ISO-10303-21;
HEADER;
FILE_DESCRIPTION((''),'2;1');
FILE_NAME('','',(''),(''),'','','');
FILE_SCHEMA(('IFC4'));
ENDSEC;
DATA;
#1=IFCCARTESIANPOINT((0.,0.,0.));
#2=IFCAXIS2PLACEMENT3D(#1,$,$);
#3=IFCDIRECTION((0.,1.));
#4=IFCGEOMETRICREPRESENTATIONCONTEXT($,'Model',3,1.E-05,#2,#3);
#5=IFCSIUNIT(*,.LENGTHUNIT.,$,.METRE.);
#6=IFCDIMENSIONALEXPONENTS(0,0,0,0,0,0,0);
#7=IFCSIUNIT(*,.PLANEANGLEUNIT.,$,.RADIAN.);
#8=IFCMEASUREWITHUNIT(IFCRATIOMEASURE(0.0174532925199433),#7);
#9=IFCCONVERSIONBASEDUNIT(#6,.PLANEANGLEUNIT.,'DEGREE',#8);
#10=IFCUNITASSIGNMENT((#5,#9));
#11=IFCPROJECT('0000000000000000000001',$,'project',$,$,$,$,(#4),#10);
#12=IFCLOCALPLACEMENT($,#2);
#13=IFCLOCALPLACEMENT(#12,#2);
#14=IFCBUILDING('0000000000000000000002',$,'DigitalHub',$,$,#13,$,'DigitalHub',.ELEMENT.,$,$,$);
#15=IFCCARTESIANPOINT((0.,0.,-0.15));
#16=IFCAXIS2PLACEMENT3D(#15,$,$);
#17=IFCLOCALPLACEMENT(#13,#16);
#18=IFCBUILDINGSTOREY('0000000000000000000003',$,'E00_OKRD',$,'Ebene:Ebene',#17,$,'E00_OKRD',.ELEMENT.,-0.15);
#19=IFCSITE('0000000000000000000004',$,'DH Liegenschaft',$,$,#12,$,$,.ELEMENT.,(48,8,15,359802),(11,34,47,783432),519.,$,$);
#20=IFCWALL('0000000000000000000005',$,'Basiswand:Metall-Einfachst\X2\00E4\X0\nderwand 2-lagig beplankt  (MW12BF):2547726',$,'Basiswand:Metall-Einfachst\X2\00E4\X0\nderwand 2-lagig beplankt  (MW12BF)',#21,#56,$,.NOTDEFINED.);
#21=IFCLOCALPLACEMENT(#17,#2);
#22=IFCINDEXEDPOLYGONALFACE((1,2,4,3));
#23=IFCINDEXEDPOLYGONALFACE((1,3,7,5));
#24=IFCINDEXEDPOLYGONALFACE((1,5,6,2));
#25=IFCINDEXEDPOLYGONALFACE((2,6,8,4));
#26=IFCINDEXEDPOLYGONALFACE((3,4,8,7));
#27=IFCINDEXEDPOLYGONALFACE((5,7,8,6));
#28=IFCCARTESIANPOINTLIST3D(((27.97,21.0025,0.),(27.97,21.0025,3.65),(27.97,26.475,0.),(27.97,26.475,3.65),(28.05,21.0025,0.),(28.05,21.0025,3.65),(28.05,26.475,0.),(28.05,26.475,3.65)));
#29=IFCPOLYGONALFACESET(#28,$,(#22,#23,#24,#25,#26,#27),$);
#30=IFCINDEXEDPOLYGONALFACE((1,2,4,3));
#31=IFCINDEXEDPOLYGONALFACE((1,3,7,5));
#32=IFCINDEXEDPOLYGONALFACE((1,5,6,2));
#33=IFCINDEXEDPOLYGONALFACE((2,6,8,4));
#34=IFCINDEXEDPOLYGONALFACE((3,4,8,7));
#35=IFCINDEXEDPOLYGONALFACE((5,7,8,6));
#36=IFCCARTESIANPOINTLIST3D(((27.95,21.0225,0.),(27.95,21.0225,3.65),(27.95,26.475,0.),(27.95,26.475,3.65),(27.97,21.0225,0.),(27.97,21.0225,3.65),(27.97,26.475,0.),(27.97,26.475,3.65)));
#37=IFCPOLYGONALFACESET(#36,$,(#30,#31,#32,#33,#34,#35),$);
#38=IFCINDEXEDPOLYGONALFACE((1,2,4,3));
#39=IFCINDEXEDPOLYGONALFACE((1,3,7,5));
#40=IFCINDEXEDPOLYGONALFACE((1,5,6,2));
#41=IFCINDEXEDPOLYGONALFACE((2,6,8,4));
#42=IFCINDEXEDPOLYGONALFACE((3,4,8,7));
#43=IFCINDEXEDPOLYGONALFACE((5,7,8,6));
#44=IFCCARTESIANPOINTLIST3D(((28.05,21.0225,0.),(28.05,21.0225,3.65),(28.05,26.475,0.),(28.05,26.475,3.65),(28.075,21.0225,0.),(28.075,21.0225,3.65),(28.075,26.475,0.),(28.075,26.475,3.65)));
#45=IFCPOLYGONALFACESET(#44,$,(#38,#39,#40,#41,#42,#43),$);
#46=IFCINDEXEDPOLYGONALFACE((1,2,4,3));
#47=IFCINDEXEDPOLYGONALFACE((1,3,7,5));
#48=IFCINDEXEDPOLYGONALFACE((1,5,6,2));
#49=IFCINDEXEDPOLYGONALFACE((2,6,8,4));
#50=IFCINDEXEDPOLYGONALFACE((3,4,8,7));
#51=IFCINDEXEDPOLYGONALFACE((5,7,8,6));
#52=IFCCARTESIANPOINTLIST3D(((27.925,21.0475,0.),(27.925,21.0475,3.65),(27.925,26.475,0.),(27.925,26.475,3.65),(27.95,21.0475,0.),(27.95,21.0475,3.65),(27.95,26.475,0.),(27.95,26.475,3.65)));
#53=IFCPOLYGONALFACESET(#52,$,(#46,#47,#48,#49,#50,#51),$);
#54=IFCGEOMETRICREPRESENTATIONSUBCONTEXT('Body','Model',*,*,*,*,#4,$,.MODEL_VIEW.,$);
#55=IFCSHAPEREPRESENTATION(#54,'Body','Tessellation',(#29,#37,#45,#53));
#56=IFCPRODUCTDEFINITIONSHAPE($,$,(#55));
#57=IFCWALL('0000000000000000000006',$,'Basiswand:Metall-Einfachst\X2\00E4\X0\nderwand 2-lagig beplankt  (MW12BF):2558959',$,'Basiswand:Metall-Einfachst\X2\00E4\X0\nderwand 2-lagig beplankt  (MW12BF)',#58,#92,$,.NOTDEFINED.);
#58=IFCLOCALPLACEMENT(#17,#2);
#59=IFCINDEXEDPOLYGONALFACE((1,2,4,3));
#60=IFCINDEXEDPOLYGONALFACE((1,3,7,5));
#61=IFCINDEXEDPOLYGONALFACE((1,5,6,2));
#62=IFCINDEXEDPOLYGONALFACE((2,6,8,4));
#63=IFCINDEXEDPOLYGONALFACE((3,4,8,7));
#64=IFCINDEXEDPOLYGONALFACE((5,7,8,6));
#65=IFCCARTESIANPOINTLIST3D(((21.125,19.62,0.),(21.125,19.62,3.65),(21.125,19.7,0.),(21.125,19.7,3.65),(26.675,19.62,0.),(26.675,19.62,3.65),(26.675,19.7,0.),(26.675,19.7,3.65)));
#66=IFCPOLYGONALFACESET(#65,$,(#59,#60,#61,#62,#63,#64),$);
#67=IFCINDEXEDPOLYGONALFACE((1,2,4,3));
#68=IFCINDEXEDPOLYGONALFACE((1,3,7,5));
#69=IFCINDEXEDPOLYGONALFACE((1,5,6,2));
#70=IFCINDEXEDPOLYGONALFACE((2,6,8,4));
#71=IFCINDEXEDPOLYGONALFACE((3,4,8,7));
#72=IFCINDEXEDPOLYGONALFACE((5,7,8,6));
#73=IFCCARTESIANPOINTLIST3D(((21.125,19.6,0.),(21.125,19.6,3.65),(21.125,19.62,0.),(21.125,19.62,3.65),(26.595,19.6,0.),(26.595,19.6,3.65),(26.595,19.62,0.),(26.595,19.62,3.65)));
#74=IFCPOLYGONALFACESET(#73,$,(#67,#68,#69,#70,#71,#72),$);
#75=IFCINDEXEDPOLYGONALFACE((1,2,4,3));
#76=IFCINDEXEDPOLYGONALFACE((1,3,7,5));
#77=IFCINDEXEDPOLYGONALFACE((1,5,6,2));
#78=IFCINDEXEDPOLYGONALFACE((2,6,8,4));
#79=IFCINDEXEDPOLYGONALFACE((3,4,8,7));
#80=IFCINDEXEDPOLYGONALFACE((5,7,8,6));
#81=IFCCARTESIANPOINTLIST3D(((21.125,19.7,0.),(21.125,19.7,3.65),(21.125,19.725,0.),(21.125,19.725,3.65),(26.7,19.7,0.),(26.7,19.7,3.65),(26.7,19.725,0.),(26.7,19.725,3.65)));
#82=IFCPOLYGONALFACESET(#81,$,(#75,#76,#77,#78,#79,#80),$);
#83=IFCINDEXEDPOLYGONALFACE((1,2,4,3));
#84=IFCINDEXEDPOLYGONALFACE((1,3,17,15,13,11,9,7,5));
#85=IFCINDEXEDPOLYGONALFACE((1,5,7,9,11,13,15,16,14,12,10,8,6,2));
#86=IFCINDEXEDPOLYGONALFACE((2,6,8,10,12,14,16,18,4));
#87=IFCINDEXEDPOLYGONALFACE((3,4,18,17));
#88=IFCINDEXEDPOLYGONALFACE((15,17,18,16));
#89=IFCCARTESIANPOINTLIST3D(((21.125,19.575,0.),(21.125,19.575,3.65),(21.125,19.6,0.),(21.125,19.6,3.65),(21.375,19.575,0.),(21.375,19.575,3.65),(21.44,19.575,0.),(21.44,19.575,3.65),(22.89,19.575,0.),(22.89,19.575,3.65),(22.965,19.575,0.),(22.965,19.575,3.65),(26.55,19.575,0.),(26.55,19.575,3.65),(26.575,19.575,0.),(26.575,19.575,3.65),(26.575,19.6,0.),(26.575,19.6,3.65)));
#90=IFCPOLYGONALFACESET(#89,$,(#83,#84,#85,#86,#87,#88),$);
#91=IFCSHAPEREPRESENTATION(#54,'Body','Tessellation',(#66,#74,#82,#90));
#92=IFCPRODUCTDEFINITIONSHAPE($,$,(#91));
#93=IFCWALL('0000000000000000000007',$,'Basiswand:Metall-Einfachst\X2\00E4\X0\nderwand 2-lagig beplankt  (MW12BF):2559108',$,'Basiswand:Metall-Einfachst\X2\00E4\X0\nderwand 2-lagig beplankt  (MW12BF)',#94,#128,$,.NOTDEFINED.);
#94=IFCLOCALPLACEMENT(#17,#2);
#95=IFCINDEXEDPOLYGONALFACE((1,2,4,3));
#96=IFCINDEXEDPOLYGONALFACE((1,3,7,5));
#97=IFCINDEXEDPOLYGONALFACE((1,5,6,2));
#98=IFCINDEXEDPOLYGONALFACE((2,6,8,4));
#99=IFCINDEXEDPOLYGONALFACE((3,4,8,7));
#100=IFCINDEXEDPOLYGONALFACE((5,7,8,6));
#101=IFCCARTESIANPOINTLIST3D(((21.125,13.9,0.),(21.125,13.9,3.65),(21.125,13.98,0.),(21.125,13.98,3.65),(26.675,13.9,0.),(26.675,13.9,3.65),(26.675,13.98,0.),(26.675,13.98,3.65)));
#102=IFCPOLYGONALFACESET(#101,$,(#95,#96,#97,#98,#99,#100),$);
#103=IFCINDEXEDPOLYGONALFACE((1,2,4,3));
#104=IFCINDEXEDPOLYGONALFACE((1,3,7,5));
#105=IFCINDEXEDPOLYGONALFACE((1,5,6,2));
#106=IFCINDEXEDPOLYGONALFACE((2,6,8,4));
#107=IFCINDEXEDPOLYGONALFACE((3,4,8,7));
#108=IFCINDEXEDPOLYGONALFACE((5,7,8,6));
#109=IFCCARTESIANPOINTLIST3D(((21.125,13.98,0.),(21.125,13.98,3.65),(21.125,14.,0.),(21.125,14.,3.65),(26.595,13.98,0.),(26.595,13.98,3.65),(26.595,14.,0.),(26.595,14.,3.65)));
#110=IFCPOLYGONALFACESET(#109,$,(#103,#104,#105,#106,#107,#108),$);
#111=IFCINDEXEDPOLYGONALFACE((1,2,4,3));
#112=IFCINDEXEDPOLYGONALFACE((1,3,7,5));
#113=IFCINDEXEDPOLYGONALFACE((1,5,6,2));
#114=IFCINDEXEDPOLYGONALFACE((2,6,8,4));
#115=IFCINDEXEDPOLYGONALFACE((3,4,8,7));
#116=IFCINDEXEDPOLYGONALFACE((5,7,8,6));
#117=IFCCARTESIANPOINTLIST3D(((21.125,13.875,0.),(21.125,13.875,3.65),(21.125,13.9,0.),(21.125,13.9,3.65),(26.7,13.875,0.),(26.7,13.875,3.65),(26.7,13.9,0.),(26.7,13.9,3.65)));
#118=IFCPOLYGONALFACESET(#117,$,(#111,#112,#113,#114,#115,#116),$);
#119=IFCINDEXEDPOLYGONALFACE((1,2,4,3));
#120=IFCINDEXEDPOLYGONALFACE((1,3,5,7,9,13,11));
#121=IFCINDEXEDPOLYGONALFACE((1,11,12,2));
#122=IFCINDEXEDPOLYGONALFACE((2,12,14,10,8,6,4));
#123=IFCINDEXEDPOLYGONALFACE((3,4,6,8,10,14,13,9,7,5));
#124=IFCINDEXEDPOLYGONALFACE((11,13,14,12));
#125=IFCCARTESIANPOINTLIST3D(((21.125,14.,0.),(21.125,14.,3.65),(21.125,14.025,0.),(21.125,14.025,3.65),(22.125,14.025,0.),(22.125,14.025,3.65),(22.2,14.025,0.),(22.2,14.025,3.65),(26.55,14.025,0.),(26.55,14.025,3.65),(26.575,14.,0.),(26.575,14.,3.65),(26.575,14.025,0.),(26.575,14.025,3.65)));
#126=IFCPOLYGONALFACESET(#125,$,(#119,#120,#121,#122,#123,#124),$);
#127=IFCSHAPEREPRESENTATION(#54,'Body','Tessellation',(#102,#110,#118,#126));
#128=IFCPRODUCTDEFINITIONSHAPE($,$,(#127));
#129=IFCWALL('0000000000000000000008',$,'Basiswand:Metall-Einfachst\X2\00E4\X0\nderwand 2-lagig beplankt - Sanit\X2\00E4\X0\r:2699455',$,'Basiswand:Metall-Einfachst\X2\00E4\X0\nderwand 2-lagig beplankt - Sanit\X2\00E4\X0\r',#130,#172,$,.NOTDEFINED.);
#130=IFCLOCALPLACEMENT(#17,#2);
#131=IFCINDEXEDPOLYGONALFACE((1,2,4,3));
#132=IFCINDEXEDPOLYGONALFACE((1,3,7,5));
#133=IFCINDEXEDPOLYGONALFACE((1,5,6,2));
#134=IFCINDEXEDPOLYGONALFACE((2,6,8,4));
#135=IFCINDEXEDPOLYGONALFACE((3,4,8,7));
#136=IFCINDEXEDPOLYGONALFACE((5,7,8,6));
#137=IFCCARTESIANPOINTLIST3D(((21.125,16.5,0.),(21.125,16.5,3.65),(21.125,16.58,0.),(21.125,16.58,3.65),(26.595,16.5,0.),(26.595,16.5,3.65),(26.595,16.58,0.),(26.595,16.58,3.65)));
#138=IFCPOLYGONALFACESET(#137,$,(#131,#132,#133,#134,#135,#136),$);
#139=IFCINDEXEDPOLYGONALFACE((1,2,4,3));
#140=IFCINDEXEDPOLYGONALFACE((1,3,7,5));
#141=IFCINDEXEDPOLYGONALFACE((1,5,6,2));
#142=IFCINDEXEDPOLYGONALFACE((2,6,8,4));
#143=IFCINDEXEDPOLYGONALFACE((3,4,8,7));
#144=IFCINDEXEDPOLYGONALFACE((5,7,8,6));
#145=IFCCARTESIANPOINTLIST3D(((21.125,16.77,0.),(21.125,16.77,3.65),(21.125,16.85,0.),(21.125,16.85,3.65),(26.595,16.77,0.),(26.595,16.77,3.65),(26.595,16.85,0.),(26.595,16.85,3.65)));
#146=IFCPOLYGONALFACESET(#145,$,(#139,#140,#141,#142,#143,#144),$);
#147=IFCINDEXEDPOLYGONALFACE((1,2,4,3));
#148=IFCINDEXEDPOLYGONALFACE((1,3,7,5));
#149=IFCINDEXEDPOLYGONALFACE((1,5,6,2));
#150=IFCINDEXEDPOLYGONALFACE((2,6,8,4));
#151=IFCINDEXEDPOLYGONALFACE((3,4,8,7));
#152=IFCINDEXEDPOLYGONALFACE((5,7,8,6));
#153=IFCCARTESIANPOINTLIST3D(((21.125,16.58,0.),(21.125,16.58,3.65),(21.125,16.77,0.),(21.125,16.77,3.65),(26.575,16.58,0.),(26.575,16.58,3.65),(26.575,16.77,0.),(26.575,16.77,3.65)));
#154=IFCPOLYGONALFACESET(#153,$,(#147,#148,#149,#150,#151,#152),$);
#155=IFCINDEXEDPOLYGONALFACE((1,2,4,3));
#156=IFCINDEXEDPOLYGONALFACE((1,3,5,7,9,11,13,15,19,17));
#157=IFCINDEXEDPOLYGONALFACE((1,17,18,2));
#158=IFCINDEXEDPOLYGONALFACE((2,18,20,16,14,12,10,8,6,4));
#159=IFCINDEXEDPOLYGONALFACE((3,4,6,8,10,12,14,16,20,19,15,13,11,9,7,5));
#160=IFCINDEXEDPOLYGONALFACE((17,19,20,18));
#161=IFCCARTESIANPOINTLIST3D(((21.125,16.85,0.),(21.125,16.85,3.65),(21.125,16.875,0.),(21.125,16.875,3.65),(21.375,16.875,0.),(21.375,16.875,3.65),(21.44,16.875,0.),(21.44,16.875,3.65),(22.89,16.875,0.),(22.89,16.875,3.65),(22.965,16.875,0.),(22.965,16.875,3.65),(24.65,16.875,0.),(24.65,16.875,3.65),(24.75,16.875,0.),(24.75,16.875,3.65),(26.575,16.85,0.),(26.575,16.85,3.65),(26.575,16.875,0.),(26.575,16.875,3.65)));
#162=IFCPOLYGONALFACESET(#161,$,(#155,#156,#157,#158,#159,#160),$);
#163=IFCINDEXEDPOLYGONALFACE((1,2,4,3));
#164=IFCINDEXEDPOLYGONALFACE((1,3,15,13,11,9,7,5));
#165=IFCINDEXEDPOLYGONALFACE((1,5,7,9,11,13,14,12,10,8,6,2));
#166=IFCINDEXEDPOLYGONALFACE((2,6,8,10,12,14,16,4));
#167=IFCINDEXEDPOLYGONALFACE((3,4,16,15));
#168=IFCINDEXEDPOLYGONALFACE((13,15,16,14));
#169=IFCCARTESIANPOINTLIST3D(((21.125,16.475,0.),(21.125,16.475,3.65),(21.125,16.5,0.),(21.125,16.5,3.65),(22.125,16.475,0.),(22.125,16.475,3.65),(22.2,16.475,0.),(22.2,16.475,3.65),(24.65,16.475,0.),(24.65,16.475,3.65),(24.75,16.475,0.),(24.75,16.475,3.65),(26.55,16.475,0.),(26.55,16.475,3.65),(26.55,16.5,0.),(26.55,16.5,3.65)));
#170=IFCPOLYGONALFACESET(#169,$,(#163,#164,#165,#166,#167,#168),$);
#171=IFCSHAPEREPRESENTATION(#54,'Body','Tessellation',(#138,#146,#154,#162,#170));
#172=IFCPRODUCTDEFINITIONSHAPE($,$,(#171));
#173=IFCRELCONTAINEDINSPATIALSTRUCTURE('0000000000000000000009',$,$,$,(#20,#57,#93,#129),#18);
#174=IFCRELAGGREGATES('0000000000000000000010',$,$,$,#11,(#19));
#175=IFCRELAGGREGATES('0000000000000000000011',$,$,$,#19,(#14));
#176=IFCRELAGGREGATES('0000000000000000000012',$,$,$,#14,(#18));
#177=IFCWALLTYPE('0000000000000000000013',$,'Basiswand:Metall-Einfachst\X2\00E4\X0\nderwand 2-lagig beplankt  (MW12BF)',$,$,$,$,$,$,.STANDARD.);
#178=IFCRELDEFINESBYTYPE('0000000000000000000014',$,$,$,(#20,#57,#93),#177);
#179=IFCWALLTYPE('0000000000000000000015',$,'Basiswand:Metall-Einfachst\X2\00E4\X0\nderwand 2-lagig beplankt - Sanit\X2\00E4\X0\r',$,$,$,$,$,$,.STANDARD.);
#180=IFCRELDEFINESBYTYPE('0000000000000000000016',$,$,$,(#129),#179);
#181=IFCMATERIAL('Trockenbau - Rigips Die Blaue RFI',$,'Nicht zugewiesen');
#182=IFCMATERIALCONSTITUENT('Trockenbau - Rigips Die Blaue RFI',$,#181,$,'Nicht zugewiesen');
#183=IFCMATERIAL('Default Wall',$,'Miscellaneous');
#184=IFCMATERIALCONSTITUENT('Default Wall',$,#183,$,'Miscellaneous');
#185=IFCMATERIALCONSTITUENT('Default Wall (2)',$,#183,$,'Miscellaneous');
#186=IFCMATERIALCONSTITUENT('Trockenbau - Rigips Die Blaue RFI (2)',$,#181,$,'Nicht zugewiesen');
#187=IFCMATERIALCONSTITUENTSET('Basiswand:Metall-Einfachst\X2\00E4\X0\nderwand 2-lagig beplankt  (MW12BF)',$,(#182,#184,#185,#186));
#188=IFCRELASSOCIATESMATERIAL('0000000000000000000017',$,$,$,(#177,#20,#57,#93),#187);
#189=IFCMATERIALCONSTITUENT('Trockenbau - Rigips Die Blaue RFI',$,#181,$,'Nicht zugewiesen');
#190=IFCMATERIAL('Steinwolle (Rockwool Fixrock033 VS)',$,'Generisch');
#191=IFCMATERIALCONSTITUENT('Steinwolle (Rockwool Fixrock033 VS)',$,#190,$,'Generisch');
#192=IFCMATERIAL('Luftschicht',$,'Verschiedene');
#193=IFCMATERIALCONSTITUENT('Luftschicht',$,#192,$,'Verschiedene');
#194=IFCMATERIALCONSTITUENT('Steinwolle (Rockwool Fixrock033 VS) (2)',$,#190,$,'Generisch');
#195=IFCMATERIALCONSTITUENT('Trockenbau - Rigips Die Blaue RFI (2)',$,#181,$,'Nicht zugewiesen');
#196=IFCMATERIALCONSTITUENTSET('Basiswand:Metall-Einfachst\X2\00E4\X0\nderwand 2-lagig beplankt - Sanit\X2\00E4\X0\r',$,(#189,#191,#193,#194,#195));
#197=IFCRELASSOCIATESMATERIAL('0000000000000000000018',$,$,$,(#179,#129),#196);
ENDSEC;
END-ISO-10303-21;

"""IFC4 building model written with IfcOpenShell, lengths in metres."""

from ifc_helpers import new_model, entity, si_unit, converted_unit, direction, frame, origin, place, context, subcontext, project, spatial, indexed_curve, outline, extrude, material, constituent, constituent_set, type_object, element, save


model = new_model("IFC4")

# Units and contexts
model_context = context("Model", 3, precision=1e-05, world=origin(), true_north=direction((0.0, 1.0)))
body_context = subcontext(model_context, "Body", "Model", "MODEL_VIEW")
ifc_project = project(units=[si_unit("LENGTHUNIT", "METRE"), converted_unit("PLANEANGLEUNIT", "DEGREE", entity("IfcRatioMeasure", 0.0174532925199433), si_unit("PLANEANGLEUNIT", "RADIAN"), dimensions=[0, 0, 0, 0, 0, 0, 0])], contexts=[model_context])

# Site, building, storey
site_placement = place(None, frame((0.0, 0.0, 0.0)))
site = spatial("IfcSite", under=ifc_project, at=site_placement, Name="DH Liegenschaft", CompositionType="ELEMENT", RefLatitude=(48, 8, 15, 359802), RefLongitude=(11, 34, 47, 783432), RefElevation=519.0)
building_placement = place(site_placement, origin())
building = spatial("IfcBuilding", under=site, at=building_placement, Name="DigitalHub", LongName="DigitalHub", CompositionType="ELEMENT")
storey_placement = place(building_placement, frame((0.0, 0.0, -0.15)))
storey = spatial("IfcBuildingStorey", under=building, at=storey_placement, Name="E00_OKRD", ObjectType="Ebene:Ebene", LongName="E00_OKRD", CompositionType="ELEMENT", Elevation=-0.15)

# Wall
ifc_material_1 = material(Name="Trockenbau - Rigips Die Blaue RFI", Category="Nicht zugewiesen")
ifc_constituent_1 = constituent(ifc_material_1, Name="Trockenbau - Rigips Die Blaue RFI", Category="Nicht zugewiesen")
ifc_material_2 = material(Name="Default Wall", Category="Miscellaneous")
ifc_constituent_2 = constituent(ifc_material_2, Name="Default Wall", Category="Miscellaneous")
ifc_constituent_3 = constituent(ifc_material_2, Name="Default Wall (2)", Category="Miscellaneous")
ifc_constituent_4 = constituent(ifc_material_1, Name="Trockenbau - Rigips Die Blaue RFI (2)", Category="Nicht zugewiesen")
ifc_constituent_set_1 = constituent_set(constituents=[ifc_constituent_1, ifc_constituent_2, ifc_constituent_3, ifc_constituent_4], Name="Basiswand:Metall-Einfachständerwand 2-lagig beplankt  (MW12BF)")
wall_type_1 = type_object("IfcWallType", Name="Basiswand:Metall-Einfachständerwand 2-lagig beplankt  (MW12BF)", PredefinedType="STANDARD", material=ifc_constituent_set_1)
wall_1_placement = place(storey_placement, frame((28.0, 26.475, 0.0), z_axis=(0.0, 0.0, 1.0), x_axis=(0.0, -1.0, 0.0)))
element("IfcWall", 1, at=wall_1_placement, inside=storey, type_object=wall_type_1, material=ifc_constituent_set_1, Name="Basiswand:Metall-Einfachständerwand 2-lagig beplankt  (MW12BF):2547726", ObjectType="Basiswand:Metall-Einfachständerwand 2-lagig beplankt  (MW12BF)", PredefinedType="NOTDEFINED", context=body_context, shape_type="SweptSolid", body=[
    extrude(outline(indexed_curve([(-2.7362, -0.04), (2.7362, -0.04), (2.7362, 0.04), (-2.7362, 0.04), (-2.7362, -0.04)], self_intersect=False)), frame((2.7362, 0.01, 0.0)), (0.0, 0.0, 1.0), 3.65),
    extrude(outline(indexed_curve([(-2.7262, -0.01), (2.7262, -0.01), (2.7262, 0.01), (-2.7262, 0.01), (-2.7262, -0.01)], self_intersect=False)), frame((2.7262, -0.04, 0.0)), (0.0, 0.0, 1.0), 3.65),
    extrude(outline(indexed_curve([(-0.0125, -2.7262), (0.0125, -2.7262), (0.0125, 2.7262), (-0.0125, 2.7262), (-0.0125, -2.7262)], self_intersect=False)), frame((2.7262, 0.0625, 0.0), z_axis=(0.0, 0.0, 1.0), x_axis=(0.0, -1.0, 0.0)), (0.0, 0.0, 1.0), 3.65),
    extrude(outline(indexed_curve([(-0.0125, -2.7137), (0.0125, -2.7137), (0.0125, 2.7137), (-0.0125, 2.7137), (-0.0125, -2.7137)], self_intersect=False)), frame((2.7137, -0.0625, 0.0), z_axis=(0.0, 0.0, 1.0), x_axis=(0.0, 1.0, 0.0)), (0.0, 0.0, 1.0), 3.65),
])

# Walls
wall_2_placement = place(storey_placement, frame((21.125, 19.65, 0.0)))
element("IfcWall", 2, at=wall_2_placement, inside=storey, type_object=wall_type_1, material=ifc_constituent_set_1, Name="Basiswand:Metall-Einfachständerwand 2-lagig beplankt  (MW12BF):2558959", ObjectType="Basiswand:Metall-Einfachständerwand 2-lagig beplankt  (MW12BF)", PredefinedType="NOTDEFINED", context=body_context, shape_type="SweptSolid", body=[
    extrude(outline(indexed_curve([(-2.775, -0.04), (2.775, -0.04), (2.775, 0.04), (-2.775, 0.04), (-2.775, -0.04)], self_intersect=False)), frame((2.775, 0.01, 0.0)), (0.0, 0.0, 1.0), 3.65),
    extrude(outline(indexed_curve([(-2.735, -0.01), (2.735, -0.01), (2.735, 0.01), (-2.735, 0.01), (-2.735, -0.01)], self_intersect=False)), frame((2.735, -0.04, 0.0)), (0.0, 0.0, 1.0), 3.65),
    extrude(outline(indexed_curve([(-0.0125, -2.7875), (0.0125, -2.7875), (0.0125, 2.7875), (-0.0125, 2.7875), (-0.0125, -2.7875)], self_intersect=False)), frame((2.7875, 0.0625, 0.0), z_axis=(0.0, 0.0, 1.0), x_axis=(0.0, -1.0, 0.0)), (0.0, 0.0, 1.0), 3.65),
    extrude(outline(indexed_curve([(-2.0272, -0.0056), (-1.9622, -0.0056), (-0.5122, -0.0056), (-0.4372, -0.0056), (3.1478, -0.0056), (3.1728, -0.0056), (3.1728, 0.0194), (-2.2772, 0.0194), (-2.2772, -0.0056), (-2.0272, -0.0056)], self_intersect=False)), frame((2.2772, -0.0694, 0.0)), (0.0, 0.0, 1.0), 3.65),
])
wall_3_placement = place(storey_placement, frame((21.125, 13.95, 0.0)))
element("IfcWall", 3, at=wall_3_placement, inside=storey, type_object=wall_type_1, material=ifc_constituent_set_1, Name="Basiswand:Metall-Einfachständerwand 2-lagig beplankt  (MW12BF):2559108", ObjectType="Basiswand:Metall-Einfachständerwand 2-lagig beplankt  (MW12BF)", PredefinedType="NOTDEFINED", context=body_context, shape_type="SweptSolid", body=[
    extrude(outline(indexed_curve([(-2.775, -0.04), (2.775, -0.04), (2.775, 0.04), (-2.775, 0.04), (-2.775, -0.04)], self_intersect=False)), frame((2.775, -0.01, 0.0)), (0.0, 0.0, 1.0), 3.65),
    extrude(outline(indexed_curve([(-2.735, -0.01), (2.735, -0.01), (2.735, 0.01), (-2.735, 0.01), (-2.735, -0.01)], self_intersect=False)), frame((2.735, 0.04, 0.0)), (0.0, 0.0, 1.0), 3.65),
    extrude(outline(indexed_curve([(-0.0125, -2.7875), (0.0125, -2.7875), (0.0125, 2.7875), (-0.0125, 2.7875), (-0.0125, -2.7875)], self_intersect=False)), frame((2.7875, -0.0625, 0.0), z_axis=(0.0, 0.0, 1.0), x_axis=(0.0, 1.0, 0.0)), (0.0, 0.0, 1.0), 3.65),
    extrude(outline(indexed_curve([(-2.7964, -0.0071), (1.5536, -0.0071), (1.6286, -0.0071), (2.6286, -0.0071), (2.6286, 0.0179), (-2.8214, 0.0179), (-2.8214, -0.0071), (-2.7964, -0.0071)], self_intersect=False)), frame((2.6286, 0.0679, 0.0), z_axis=(0.0, 0.0, 1.0), x_axis=(-1.0, 0.0, 0.0)), (0.0, 0.0, 1.0), 3.65),
])

# Wall
ifc_constituent_5 = constituent(ifc_material_1, Name="Trockenbau - Rigips Die Blaue RFI", Category="Nicht zugewiesen")
ifc_material_3 = material(Name="Steinwolle (Rockwool Fixrock033 VS)", Category="Generisch")
ifc_constituent_6 = constituent(ifc_material_3, Name="Steinwolle (Rockwool Fixrock033 VS)", Category="Generisch")
ifc_material_4 = material(Name="Luftschicht", Category="Verschiedene")
ifc_constituent_7 = constituent(ifc_material_4, Name="Luftschicht", Category="Verschiedene")
ifc_constituent_8 = constituent(ifc_material_3, Name="Steinwolle (Rockwool Fixrock033 VS) (2)", Category="Generisch")
ifc_constituent_9 = constituent(ifc_material_1, Name="Trockenbau - Rigips Die Blaue RFI (2)", Category="Nicht zugewiesen")
ifc_constituent_set_2 = constituent_set(constituents=[ifc_constituent_5, ifc_constituent_6, ifc_constituent_7, ifc_constituent_8, ifc_constituent_9], Name="Basiswand:Metall-Einfachständerwand 2-lagig beplankt - Sanitär")
wall_type_2 = type_object("IfcWallType", Name="Basiswand:Metall-Einfachständerwand 2-lagig beplankt - Sanitär", PredefinedType="STANDARD", material=ifc_constituent_set_2)
wall_4_placement = place(storey_placement, frame((21.125, 16.675, 0.0)))
element("IfcWall", 4, at=wall_4_placement, inside=storey, type_object=wall_type_2, material=ifc_constituent_set_2, Name="Basiswand:Metall-Einfachständerwand 2-lagig beplankt - Sanitär:2699455", ObjectType="Basiswand:Metall-Einfachständerwand 2-lagig beplankt - Sanitär", PredefinedType="NOTDEFINED", context=body_context, shape_type="SweptSolid", body=[
    extrude(outline(indexed_curve([(-2.735, -0.04), (2.735, -0.04), (2.735, 0.04), (-2.735, 0.04), (-2.735, -0.04)], self_intersect=False)), frame((2.735, -0.135, 0.0)), (0.0, 0.0, 1.0), 3.65),
    extrude(outline(indexed_curve([(-2.735, -0.04), (2.735, -0.04), (2.735, 0.04), (-2.735, 0.04), (-2.735, -0.04)], self_intersect=False)), frame((2.735, 0.135, 0.0)), (0.0, 0.0, 1.0), 3.65),
    extrude(outline(indexed_curve([(-2.725, -0.095), (2.725, -0.095), (2.725, 0.095), (-2.725, 0.095), (-2.725, -0.095)], self_intersect=False)), frame((2.725, 0.0, 0.0)), (0.0, 0.0, 1.0), 3.65),
    extrude(outline(indexed_curve([(-1.403, -0.005), (-1.303, -0.005), (0.382, -0.005), (0.457, -0.005), (1.907, -0.005), (1.972, -0.005), (2.222, -0.005), (2.222, 0.02), (-3.228, 0.02), (-3.228, -0.005), (-1.403, -0.005)], self_intersect=False)), frame((2.222, 0.195, 0.0), z_axis=(0.0, 0.0, 1.0), x_axis=(-1.0, 0.0, 0.0)), (0.0, 0.0, 1.0), 3.65),
    extrude(outline(indexed_curve([(-1.5094, -0.0063), (-1.4344, -0.0063), (1.0156, -0.0062), (1.1156, -0.0062), (2.9156, -0.0062), (2.9156, 0.0188), (-2.5094, 0.0187), (-2.5094, -0.0063), (-1.5094, -0.0063)], self_intersect=False)), frame((2.5094, -0.1938, 0.0)), (0.0, 0.0, 1.0), 3.65),
])

save(model, "model.ifc")
